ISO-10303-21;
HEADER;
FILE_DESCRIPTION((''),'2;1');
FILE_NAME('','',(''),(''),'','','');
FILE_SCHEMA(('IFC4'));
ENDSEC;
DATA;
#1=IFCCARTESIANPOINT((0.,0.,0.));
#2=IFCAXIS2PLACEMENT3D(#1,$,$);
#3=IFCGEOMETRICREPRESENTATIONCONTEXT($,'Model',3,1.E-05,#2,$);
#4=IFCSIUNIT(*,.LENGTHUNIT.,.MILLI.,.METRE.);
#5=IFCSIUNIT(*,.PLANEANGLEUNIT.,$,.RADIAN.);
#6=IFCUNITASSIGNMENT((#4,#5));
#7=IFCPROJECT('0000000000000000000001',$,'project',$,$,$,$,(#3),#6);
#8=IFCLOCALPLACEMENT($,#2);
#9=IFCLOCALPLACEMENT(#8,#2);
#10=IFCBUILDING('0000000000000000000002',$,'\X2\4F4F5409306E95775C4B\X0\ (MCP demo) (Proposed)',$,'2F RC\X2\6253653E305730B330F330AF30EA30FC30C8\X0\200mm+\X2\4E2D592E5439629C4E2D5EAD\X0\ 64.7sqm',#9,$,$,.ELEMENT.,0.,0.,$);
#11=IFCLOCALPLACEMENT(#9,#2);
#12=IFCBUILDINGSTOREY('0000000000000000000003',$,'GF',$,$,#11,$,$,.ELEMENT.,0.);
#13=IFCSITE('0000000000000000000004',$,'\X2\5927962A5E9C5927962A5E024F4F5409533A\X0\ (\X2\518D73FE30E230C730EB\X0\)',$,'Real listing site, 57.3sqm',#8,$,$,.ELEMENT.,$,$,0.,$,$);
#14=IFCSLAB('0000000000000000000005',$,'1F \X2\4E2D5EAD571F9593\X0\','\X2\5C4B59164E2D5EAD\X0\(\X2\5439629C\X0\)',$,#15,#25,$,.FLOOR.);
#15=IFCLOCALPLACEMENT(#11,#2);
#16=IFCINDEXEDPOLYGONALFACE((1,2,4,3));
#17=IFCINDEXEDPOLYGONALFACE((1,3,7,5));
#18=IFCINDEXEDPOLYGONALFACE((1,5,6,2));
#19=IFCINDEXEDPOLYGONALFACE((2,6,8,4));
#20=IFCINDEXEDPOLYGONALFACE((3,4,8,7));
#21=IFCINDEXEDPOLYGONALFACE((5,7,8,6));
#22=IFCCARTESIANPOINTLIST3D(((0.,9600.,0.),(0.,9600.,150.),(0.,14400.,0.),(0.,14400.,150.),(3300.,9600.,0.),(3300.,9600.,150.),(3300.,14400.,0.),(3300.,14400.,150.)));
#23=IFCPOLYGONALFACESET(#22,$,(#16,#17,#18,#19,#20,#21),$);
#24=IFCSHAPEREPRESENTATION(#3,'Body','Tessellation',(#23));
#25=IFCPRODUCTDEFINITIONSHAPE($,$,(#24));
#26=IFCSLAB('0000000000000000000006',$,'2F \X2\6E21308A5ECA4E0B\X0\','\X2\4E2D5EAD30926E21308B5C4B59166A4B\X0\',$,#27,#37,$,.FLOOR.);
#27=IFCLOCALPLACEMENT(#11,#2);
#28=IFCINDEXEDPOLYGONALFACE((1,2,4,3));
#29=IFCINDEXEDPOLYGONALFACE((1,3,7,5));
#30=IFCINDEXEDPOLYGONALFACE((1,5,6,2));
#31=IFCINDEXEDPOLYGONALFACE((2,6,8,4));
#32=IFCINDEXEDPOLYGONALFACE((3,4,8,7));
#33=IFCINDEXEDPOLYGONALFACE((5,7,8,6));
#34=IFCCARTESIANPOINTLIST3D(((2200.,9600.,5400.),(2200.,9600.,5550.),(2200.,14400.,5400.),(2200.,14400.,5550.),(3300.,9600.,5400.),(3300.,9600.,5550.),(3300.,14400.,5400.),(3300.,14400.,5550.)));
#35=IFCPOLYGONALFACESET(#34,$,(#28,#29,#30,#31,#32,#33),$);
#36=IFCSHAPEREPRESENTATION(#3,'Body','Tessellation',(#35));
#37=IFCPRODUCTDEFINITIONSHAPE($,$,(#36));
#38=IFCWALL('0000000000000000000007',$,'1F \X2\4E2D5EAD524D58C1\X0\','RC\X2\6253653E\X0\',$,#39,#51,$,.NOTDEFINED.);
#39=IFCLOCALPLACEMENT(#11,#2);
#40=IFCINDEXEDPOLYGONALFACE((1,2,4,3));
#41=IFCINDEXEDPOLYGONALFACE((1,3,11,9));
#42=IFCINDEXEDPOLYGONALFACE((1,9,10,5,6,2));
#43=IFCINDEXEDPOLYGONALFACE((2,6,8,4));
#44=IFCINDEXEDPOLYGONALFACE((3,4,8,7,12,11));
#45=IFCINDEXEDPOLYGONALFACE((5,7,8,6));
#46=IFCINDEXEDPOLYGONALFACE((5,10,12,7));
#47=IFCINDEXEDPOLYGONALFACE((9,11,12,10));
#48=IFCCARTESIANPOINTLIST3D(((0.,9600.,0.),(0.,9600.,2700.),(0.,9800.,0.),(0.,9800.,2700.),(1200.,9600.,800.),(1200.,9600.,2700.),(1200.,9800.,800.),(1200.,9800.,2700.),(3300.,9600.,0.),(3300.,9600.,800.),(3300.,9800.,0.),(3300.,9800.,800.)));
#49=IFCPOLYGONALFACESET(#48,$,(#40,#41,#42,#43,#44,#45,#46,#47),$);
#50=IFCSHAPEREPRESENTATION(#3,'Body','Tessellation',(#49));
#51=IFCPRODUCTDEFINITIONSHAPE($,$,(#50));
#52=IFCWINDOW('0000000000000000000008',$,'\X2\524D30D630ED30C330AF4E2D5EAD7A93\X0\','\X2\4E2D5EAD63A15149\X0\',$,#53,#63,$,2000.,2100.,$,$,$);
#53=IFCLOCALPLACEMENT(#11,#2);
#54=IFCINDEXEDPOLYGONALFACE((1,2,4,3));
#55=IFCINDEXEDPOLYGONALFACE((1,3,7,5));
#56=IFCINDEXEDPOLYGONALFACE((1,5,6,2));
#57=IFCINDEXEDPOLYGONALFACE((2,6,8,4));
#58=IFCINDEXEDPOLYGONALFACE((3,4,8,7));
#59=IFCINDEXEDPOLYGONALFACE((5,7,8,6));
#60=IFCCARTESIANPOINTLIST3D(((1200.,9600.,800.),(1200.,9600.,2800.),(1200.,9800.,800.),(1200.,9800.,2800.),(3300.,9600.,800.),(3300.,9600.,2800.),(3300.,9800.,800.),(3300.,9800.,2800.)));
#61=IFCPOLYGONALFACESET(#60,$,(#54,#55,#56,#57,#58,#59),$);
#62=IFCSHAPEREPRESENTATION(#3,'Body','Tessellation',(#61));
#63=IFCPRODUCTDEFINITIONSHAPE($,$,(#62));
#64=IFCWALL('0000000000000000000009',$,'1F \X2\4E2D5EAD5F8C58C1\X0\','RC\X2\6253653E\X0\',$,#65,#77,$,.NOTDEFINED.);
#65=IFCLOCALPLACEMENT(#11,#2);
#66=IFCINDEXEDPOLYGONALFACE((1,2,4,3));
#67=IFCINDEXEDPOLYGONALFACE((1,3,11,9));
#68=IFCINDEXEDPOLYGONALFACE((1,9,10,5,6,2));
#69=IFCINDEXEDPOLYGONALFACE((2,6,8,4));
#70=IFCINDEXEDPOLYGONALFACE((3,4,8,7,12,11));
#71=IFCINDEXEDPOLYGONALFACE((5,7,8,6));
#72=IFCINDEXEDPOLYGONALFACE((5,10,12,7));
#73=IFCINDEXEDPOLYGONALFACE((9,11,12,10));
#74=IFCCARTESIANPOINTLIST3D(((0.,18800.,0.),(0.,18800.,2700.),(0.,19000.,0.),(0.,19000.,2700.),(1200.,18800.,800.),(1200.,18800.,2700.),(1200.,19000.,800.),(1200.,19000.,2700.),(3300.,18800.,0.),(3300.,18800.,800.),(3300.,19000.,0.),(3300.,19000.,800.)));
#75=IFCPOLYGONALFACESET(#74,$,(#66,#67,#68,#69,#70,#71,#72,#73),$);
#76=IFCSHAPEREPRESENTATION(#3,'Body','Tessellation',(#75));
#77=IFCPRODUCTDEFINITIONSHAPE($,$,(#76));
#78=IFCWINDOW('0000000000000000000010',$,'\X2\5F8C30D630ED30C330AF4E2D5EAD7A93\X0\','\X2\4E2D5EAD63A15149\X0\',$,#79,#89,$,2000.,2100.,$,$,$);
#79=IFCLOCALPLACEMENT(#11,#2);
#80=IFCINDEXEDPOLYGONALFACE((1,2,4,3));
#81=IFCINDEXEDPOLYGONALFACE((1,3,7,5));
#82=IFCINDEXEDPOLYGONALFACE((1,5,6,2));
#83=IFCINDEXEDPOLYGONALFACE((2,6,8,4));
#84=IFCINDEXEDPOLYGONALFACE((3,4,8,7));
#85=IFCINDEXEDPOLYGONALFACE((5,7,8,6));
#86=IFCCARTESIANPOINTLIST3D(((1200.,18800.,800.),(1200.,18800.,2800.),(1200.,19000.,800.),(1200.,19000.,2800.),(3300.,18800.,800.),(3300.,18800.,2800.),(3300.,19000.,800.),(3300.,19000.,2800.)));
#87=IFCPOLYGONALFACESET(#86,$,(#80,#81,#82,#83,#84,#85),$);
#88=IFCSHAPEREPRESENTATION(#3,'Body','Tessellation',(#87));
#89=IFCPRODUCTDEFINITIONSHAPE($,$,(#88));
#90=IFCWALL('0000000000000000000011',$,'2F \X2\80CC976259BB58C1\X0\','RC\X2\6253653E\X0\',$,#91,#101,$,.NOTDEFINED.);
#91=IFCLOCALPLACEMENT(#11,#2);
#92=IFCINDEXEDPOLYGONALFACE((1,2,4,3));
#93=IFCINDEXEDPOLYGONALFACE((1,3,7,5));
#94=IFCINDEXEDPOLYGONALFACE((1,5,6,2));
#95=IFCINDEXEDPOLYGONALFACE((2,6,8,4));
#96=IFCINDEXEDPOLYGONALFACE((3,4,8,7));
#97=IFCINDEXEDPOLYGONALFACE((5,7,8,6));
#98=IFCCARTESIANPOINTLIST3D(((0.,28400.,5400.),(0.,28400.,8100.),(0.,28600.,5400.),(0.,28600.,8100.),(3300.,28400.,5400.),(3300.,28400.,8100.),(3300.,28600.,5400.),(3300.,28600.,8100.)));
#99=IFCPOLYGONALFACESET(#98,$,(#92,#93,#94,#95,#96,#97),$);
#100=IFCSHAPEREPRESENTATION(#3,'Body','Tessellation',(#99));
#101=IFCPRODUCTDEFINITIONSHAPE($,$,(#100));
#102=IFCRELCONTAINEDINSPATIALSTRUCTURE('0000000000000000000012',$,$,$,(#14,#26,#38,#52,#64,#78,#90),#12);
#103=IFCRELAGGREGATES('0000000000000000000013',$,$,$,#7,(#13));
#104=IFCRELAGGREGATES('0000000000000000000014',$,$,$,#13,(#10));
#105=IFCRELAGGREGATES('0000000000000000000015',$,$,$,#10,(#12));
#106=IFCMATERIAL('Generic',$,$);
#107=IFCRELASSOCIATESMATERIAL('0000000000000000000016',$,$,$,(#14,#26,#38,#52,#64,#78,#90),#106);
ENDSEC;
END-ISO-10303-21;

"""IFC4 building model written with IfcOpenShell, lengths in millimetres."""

from ifc_helpers import new_model, si_unit, frame, frame_2d, origin, place, context, project, spatial, rectangle, extrude, material, element, fill, save


model = new_model("IFC4")

# Units and contexts
model_context = context("Model", 3, precision=1e-05, world=origin())
ifc_project = project(units=[si_unit("LENGTHUNIT", "METRE", prefix="MILLI"), si_unit("PLANEANGLEUNIT", "RADIAN")], contexts=[model_context])

# Site, building, storey
site_placement = place(None, origin())
site = spatial("IfcSite", under=ifc_project, at=site_placement, Name="大阪府大阪市住吉区 (再現モデル)", ObjectType="Real listing site, 57.3sqm", CompositionType="ELEMENT", RefElevation=0.0)
building_placement = place(site_placement, origin())
building = spatial("IfcBuilding", under=site, at=building_placement, Name="住吉の長屋 (MCP demo) (Proposed)", ObjectType="2F RC打放しコンクリート200mm+中央吹抜中庭 64.7sqm", CompositionType="ELEMENT", ElevationOfRefHeight=0.0, ElevationOfTerrain=0.0)
storey_placement = place(building_placement, origin())
storey = spatial("IfcBuildingStorey", under=building, at=storey_placement, Name="GF", CompositionType="ELEMENT", Elevation=0.0)

# Slabs
ifc_material_1 = material(Name="Generic")
slab_1_placement = place(storey_placement, frame((0.0, 4800.0, 0.0)))
element("IfcSlab", 1, at=slab_1_placement, inside=storey, material=ifc_material_1, Name="1F 中庭土間", Description="屋外中庭(吹抜)", PredefinedType="FLOOR", context=model_context, shape_type="SweptSolid", body=[
    extrude(rectangle(XDim=3300.0, YDim=4800.0, at=frame_2d((1650.0, 2400.0))), frame((0.0, 4800.0, 0.0)), (0.0, 0.0, 1.0), 150.0),
])
slab_2_placement = place(storey_placement, frame((1100.0, 4800.0, 2700.0)))
element("IfcSlab", 2, at=slab_2_placement, inside=storey, material=ifc_material_1, Name="2F 渡り廊下", Description="中庭を渡る屋外橋", PredefinedType="FLOOR", context=model_context, shape_type="SweptSolid", body=[
    extrude(rectangle(XDim=1100.0, YDim=4800.0, at=frame_2d((550.0, 2400.0))), frame((1100.0, 4800.0, 2700.0)), (0.0, 0.0, 1.0), 150.0),
])

# Walls, openings, windows
wall_1_placement = place(storey_placement, frame((0.0, 4800.0, 0.0)))
wall_1 = element("IfcWall", 3, at=wall_1_placement, inside=storey, material=ifc_material_1, Name="1F 中庭前壁", Description="RC打放", PredefinedType="NOTDEFINED", context=model_context, shape_type="SweptSolid", body=[
    extrude(rectangle(XDim=3300.0, YDim=200.0, at=frame_2d((1650.0, 100.0))), frame((0.0, 4800.0, 0.0)), (0.0, 0.0, 1.0), 2700.0),
])
opening_1_placement = place(storey_placement, frame((600.0, 4800.0, 400.0)))
opening_1 = element("IfcOpeningElement", 4, at=opening_1_placement, cuts=wall_1, PredefinedType="NOTDEFINED", context=model_context, shape_type="SweptSolid", body=[
    extrude(rectangle(XDim=2100.0, YDim=200.0, at=frame_2d((1050.0, 100.0))), frame((600.0, 4800.0, 400.0)), (0.0, 0.0, 1.0), 2000.0),
])
window_1_placement = place(storey_placement, frame((600.0, 4800.0, 400.0)))
window_1 = element("IfcWindow", 5, at=window_1_placement, inside=storey, material=ifc_material_1, Name="前ブロック中庭窓", Description="中庭採光", OverallHeight=2000.0, OverallWidth=2100.0, context=model_context, shape_type="SweptSolid", body=[
    extrude(rectangle(XDim=2100.0, YDim=200.0, at=frame_2d((1050.0, 100.0))), frame((600.0, 4800.0, 400.0)), (0.0, 0.0, 1.0), 2000.0),
])
fill(opening_1, window_1)
wall_2_placement = place(storey_placement, frame((0.0, 9400.0, 0.0)))
wall_2 = element("IfcWall", 6, at=wall_2_placement, inside=storey, material=ifc_material_1, Name="1F 中庭後壁", Description="RC打放", PredefinedType="NOTDEFINED", context=model_context, shape_type="SweptSolid", body=[
    extrude(rectangle(XDim=3300.0, YDim=200.0, at=frame_2d((1650.0, 100.0))), frame((0.0, 9400.0, 0.0)), (0.0, 0.0, 1.0), 2700.0),
])
opening_2_placement = place(storey_placement, frame((600.0, 9400.0, 400.0)))
opening_2 = element("IfcOpeningElement", 7, at=opening_2_placement, cuts=wall_2, PredefinedType="NOTDEFINED", context=model_context, shape_type="SweptSolid", body=[
    extrude(rectangle(XDim=2100.0, YDim=200.0, at=frame_2d((1050.0, 100.0))), frame((600.0, 9400.0, 400.0)), (0.0, 0.0, 1.0), 2000.0),
])
window_2_placement = place(storey_placement, frame((600.0, 9400.0, 400.0)))
window_2 = element("IfcWindow", 8, at=window_2_placement, inside=storey, material=ifc_material_1, Name="後ブロック中庭窓", Description="中庭採光", OverallHeight=2000.0, OverallWidth=2100.0, context=model_context, shape_type="SweptSolid", body=[
    extrude(rectangle(XDim=2100.0, YDim=200.0, at=frame_2d((1050.0, 100.0))), frame((600.0, 9400.0, 400.0)), (0.0, 0.0, 1.0), 2000.0),
])
fill(opening_2, window_2)

# Wall
wall_3_placement = place(storey_placement, frame((0.0, 14200.0, 2700.0)))
element("IfcWall", 9, at=wall_3_placement, inside=storey, material=ifc_material_1, Name="2F 背面妻壁", Description="RC打放", PredefinedType="NOTDEFINED", context=model_context, shape_type="SweptSolid", body=[
    extrude(rectangle(XDim=3300.0, YDim=200.0, at=frame_2d((1650.0, 100.0))), frame((0.0, 14200.0, 2700.0)), (0.0, 0.0, 1.0), 2700.0),
])

save(model, "model.ifc")
